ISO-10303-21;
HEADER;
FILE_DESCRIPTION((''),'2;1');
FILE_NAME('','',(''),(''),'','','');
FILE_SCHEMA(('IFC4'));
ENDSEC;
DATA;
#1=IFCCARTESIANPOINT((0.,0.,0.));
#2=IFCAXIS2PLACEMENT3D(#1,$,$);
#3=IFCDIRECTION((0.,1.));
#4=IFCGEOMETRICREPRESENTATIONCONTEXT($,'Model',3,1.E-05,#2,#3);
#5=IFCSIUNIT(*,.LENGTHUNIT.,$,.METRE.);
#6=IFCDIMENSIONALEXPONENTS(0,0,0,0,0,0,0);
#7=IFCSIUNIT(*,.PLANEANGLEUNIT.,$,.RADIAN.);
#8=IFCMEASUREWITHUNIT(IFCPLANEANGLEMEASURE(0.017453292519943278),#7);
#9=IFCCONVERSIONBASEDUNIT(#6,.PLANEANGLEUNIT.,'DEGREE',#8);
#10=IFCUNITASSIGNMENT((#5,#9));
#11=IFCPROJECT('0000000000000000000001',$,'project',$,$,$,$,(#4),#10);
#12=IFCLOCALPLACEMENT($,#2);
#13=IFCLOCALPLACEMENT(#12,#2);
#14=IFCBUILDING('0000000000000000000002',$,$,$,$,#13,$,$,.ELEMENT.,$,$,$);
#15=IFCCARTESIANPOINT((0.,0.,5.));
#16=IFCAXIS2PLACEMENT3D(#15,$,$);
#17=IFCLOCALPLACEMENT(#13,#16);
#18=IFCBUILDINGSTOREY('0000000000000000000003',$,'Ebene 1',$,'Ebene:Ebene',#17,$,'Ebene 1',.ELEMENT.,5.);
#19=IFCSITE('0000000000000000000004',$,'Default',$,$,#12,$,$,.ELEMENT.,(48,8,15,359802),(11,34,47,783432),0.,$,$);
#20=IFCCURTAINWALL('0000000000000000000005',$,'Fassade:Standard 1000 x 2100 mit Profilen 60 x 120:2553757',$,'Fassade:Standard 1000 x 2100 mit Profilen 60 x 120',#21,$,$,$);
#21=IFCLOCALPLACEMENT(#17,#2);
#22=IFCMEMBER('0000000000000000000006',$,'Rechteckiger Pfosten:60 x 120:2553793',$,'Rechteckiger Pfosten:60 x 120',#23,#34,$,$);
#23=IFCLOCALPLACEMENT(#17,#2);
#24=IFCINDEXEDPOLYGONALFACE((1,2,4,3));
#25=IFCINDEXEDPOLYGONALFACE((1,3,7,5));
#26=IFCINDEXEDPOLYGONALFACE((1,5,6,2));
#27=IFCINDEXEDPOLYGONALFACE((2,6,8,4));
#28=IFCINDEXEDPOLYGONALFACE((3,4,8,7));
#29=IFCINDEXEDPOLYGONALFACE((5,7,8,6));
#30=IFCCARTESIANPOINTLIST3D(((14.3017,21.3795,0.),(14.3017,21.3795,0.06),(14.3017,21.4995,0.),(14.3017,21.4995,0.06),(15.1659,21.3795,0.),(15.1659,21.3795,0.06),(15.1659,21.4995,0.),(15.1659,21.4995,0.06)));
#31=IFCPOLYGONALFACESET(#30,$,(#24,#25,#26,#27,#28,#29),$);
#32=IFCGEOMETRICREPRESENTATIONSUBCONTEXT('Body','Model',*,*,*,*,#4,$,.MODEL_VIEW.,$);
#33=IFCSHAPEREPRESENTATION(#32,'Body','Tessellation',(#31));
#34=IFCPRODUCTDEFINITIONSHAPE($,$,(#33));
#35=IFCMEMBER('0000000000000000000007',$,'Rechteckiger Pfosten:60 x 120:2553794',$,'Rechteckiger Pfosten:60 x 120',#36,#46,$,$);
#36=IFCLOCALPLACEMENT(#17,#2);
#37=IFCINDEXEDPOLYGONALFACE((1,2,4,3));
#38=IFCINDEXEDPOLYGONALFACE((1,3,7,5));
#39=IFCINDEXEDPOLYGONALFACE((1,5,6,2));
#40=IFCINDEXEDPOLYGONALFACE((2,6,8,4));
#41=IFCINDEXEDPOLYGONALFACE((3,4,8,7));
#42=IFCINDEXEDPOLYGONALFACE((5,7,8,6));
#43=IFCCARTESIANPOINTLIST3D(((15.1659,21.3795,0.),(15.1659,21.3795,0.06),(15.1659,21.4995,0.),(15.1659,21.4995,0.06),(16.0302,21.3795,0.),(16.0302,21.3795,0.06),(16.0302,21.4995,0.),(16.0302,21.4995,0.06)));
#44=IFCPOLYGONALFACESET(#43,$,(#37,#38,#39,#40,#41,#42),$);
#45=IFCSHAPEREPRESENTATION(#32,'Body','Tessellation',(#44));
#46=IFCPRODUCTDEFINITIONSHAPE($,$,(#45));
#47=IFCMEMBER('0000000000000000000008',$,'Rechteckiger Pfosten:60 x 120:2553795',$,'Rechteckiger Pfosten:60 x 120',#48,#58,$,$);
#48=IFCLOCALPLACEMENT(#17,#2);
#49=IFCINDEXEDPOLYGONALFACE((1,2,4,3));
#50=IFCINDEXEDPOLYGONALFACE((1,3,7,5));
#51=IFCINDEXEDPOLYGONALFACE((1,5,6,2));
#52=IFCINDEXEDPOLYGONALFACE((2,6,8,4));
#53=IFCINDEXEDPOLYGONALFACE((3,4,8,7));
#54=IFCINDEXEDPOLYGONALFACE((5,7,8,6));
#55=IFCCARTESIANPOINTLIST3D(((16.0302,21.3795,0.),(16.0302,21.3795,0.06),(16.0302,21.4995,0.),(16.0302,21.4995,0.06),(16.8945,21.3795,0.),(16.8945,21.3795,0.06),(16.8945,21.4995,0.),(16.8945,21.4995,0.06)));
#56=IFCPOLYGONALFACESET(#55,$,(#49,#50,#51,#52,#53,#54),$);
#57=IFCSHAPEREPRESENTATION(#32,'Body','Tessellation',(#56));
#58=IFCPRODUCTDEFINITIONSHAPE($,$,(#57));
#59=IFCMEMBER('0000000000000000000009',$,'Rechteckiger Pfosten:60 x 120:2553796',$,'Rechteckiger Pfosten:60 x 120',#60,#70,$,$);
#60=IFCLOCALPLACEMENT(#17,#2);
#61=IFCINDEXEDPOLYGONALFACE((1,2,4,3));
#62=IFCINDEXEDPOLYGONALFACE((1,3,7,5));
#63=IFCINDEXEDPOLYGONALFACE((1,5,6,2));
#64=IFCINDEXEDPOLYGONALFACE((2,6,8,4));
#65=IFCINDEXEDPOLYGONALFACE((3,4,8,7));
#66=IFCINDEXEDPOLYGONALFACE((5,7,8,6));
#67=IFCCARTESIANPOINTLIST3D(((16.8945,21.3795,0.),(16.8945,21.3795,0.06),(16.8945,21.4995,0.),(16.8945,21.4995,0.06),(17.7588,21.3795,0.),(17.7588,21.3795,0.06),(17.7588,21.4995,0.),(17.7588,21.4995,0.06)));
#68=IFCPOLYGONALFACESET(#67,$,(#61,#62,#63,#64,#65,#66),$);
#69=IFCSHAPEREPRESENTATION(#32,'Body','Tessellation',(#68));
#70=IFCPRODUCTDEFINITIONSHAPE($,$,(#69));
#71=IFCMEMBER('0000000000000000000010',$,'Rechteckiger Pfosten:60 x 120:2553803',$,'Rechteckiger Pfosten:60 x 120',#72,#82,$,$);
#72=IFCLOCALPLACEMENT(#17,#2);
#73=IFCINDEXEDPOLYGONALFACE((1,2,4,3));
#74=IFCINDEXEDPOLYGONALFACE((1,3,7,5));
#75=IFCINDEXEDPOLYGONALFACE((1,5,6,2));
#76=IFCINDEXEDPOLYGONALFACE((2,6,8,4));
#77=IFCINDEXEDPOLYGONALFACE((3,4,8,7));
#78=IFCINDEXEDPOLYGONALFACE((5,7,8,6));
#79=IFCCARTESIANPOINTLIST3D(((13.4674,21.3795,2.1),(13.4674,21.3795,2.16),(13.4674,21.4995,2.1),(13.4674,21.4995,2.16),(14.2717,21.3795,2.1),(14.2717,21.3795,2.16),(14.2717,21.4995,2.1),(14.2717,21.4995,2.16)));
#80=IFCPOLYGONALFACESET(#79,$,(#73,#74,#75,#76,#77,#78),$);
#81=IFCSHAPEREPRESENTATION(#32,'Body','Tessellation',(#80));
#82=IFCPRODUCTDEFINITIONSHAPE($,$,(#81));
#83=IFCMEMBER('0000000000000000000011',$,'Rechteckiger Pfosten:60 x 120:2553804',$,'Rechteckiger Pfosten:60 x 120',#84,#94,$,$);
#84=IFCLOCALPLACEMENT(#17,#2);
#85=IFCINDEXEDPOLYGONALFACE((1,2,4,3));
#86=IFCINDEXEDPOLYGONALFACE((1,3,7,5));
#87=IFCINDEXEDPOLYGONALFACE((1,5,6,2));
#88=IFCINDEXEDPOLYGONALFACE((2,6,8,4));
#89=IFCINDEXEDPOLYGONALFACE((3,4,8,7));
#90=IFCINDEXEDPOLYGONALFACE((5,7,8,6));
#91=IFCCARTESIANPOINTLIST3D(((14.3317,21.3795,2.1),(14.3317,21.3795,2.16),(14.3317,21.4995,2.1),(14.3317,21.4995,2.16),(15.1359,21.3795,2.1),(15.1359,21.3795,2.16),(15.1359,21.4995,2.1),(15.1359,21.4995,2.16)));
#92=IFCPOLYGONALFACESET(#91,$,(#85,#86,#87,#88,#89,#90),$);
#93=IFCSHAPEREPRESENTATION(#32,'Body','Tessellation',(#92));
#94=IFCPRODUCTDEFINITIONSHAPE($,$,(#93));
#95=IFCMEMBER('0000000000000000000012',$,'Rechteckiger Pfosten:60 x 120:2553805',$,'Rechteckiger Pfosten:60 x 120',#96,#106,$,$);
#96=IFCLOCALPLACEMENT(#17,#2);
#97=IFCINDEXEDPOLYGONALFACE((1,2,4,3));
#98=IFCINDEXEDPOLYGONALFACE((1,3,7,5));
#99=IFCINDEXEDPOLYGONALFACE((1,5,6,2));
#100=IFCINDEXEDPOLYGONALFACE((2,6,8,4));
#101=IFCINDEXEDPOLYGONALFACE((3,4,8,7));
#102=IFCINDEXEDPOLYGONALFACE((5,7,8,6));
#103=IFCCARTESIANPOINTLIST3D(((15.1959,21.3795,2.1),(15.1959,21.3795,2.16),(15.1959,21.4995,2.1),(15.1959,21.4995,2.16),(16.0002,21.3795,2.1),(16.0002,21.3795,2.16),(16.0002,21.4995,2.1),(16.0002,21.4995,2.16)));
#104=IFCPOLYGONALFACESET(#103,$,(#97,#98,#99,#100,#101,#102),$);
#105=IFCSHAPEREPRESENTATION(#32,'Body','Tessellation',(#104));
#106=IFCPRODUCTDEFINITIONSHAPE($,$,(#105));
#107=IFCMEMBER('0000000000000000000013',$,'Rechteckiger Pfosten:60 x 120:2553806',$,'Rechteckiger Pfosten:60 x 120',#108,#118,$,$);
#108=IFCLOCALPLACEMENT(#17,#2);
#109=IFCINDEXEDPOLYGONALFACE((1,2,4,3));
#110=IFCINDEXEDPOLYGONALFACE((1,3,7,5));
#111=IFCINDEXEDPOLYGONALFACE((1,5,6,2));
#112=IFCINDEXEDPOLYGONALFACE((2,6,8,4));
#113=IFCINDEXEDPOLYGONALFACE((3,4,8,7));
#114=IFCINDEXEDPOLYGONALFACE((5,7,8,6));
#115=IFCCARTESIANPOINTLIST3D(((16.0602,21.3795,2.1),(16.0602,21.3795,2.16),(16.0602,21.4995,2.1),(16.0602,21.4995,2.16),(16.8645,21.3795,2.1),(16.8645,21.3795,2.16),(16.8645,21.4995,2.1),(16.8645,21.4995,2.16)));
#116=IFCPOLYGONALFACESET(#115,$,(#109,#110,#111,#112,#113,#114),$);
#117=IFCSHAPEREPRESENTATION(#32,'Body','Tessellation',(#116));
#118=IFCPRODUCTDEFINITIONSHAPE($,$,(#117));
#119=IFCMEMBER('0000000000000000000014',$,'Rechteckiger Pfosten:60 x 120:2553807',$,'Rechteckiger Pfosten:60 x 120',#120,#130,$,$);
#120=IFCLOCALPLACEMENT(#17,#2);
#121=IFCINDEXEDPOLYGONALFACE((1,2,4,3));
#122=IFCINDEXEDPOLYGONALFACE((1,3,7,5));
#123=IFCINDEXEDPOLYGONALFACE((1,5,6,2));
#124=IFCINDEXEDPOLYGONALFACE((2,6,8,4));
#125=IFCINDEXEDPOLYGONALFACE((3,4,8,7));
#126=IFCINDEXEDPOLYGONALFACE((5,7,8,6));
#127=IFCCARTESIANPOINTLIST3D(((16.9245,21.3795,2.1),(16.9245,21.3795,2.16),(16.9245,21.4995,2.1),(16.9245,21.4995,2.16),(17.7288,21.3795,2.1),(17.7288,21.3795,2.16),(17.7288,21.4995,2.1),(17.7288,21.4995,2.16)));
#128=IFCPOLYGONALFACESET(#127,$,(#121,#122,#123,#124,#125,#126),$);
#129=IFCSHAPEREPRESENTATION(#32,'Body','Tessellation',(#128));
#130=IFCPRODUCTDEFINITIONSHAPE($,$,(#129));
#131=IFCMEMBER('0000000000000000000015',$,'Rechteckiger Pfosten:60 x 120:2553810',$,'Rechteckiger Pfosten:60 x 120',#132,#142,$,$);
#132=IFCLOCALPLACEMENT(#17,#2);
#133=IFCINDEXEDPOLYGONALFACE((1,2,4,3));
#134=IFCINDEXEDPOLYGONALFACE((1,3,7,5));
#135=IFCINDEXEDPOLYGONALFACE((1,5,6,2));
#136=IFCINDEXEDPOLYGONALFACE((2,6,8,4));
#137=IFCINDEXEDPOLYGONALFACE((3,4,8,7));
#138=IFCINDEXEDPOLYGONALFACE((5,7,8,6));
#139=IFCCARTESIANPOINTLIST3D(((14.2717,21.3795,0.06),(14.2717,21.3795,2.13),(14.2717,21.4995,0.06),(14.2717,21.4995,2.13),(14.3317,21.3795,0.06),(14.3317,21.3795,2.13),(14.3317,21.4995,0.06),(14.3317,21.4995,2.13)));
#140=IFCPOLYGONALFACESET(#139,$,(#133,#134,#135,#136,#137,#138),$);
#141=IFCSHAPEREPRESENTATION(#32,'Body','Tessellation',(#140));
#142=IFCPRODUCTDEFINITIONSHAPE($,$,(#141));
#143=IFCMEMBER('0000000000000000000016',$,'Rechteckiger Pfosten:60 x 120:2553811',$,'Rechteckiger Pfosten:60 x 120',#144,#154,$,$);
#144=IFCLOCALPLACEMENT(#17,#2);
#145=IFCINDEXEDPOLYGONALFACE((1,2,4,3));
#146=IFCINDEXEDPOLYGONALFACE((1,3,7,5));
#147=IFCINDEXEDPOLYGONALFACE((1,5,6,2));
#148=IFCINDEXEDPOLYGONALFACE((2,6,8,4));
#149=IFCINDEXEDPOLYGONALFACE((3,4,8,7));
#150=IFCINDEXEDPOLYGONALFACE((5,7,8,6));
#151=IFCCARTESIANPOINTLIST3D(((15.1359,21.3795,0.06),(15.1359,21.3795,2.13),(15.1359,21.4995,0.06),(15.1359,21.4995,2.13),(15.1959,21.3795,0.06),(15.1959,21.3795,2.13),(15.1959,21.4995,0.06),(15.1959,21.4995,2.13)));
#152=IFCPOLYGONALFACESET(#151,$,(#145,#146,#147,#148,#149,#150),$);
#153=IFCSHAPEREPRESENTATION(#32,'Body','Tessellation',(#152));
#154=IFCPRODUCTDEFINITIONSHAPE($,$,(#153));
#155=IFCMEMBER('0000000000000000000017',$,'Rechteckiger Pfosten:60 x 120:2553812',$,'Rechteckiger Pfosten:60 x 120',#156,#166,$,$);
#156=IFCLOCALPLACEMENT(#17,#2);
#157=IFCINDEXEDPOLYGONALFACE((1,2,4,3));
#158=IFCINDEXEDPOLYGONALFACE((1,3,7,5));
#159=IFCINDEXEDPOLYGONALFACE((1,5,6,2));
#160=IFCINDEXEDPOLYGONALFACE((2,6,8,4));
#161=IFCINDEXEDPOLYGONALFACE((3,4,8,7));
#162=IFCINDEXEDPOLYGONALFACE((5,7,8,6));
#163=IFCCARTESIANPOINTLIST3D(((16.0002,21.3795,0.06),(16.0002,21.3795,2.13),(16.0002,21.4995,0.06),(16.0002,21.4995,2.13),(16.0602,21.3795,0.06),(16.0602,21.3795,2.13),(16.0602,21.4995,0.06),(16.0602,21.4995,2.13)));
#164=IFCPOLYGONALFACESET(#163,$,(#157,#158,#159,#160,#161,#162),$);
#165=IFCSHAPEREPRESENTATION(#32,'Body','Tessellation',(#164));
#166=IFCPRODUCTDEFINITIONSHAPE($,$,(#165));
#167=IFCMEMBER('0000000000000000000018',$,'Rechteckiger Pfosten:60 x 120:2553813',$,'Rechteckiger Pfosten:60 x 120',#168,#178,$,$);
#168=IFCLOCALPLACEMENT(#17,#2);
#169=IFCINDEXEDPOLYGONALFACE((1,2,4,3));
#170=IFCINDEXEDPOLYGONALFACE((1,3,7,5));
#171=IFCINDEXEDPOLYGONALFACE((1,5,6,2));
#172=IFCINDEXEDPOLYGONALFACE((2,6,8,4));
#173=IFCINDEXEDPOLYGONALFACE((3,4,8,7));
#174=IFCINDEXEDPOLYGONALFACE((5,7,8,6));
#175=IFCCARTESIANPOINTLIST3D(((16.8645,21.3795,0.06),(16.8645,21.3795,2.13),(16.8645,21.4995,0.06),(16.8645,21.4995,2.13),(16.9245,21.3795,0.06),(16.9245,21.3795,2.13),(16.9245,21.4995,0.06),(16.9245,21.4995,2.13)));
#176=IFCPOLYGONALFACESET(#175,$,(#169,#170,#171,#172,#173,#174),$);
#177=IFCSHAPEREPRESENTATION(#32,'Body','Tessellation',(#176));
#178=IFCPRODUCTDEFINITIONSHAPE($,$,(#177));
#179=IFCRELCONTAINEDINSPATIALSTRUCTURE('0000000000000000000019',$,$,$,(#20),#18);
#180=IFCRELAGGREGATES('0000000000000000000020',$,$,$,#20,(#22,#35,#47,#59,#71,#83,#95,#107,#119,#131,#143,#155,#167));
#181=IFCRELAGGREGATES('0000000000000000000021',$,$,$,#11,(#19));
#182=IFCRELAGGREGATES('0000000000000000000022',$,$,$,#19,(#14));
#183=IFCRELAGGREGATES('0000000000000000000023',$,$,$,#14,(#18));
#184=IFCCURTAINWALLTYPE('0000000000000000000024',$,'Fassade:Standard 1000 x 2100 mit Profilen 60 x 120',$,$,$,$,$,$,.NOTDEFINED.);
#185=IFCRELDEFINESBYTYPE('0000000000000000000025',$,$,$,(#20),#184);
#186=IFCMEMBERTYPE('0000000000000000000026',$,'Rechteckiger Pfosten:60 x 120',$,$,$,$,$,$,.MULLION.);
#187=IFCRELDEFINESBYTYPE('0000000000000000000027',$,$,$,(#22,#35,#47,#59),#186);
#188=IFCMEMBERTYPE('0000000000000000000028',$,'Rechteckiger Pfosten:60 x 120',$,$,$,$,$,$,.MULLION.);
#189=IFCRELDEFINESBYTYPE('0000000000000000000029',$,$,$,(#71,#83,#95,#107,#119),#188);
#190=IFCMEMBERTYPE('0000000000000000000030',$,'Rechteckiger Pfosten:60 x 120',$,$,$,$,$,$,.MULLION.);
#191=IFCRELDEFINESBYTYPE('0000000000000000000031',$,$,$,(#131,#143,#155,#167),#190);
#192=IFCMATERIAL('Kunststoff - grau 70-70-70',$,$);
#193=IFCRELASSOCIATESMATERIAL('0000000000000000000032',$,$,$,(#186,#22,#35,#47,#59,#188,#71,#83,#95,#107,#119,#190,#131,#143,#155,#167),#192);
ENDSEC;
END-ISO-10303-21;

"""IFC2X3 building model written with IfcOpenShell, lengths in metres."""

from ifc_helpers import new_model, entity, si_unit, converted_unit, direction, frame, frame_2d, origin, origin_2d_with_axis, place, context, subcontext, project, spatial, rectangle, extrude, source, transform, mapped, material, type_object, type_shapes, element, aggregate, save


model = new_model("IFC2X3")

# Units and contexts
model_context = context("Model", 3, precision=1e-05, world=origin(), true_north=direction((0.0, 1.0)))
body_context = subcontext(model_context, "Body", "Model", "MODEL_VIEW")
ifc_project = project(units=[si_unit("LENGTHUNIT", "METRE"), converted_unit("PLANEANGLEUNIT", "DEGREE", entity("IfcPlaneAngleMeasure", 0.017453292519943278), si_unit("PLANEANGLEUNIT", "RADIAN"), dimensions=[0, 0, 0, 0, 0, 0, 0])], contexts=[model_context])

# Site, building, storey
site_placement = place(None, origin())
site = spatial("IfcSite", under=ifc_project, at=site_placement, Name="Default", CompositionType="ELEMENT", RefLatitude=(48, 8, 15, 359802), RefLongitude=(11, 34, 47, 783432), RefElevation=0.0)
building_placement = place(site_placement, origin())
building = spatial("IfcBuilding", under=site, at=building_placement, CompositionType="ELEMENT")
storey_placement = place(building_placement, frame((0.0, 0.0, 5.0)))
storey = spatial("IfcBuildingStorey", under=building, at=storey_placement, Name="Ebene 1", ObjectType="Ebene:Ebene", LongName="Ebene 1", CompositionType="ELEMENT", Elevation=5.0)

# Curtain wall, members
curtain_wall_type = type_object("IfcCurtainWallType", Name="Fassade:Standard 1000 x 2100 mit Profilen 60 x 120", PredefinedType="NOTDEFINED")
curtain_wall_placement = place(storey_placement, frame((0.0, 0.0, -5.0)))
curtain_wall = element("IfcCurtainWall", 1, at=curtain_wall_placement, inside=storey, type_object=curtain_wall_type, Name="Fassade:Standard 1000 x 2100 mit Profilen 60 x 120:2553757", ObjectType="Fassade:Standard 1000 x 2100 mit Profilen 60 x 120")
ifc_material_1 = material(Name="Kunststoff - grau 70-70-70")
member_type_1 = type_object("IfcMemberType", Name="Rechteckiger Pfosten:60 x 120", PredefinedType="MULLION", material=ifc_material_1)
shared_shape_1 = source(origin(), body_context, "Body", "SweptSolid", [
    extrude(rectangle(XDim=0.06, YDim=0.12, at=origin_2d_with_axis()), frame((-0.03, 0.0, -0.8643), z_axis=(0.0, 0.0, 1.0), x_axis=(-1.0, 0.0, 0.0)), (0.0, 0.0, 1.0), 0.8643),
])
type_shapes(member_type_1, [shared_shape_1])
member_1_placement = place(curtain_wall_placement, frame((14.3017, 21.4395, 5.0), z_axis=(-1.0, 0.0, 0.0), x_axis=(0.0, 0.0, -1.0)))
member_1 = element("IfcMember", 2, at=member_1_placement, type_object=member_type_1, material=ifc_material_1, Name="Rechteckiger Pfosten:60 x 120:2553793", ObjectType="Rechteckiger Pfosten:60 x 120", context=body_context, shape_type="MappedRepresentation", body=[
    mapped(shared_shape_1, transform((0.0, 0.0, 0.0), scale=1.0)),
])
member_2_placement = place(curtain_wall_placement, frame((15.1659, 21.4395, 5.0), z_axis=(-1.0, 0.0, 0.0), x_axis=(0.0, 0.0, -1.0)))
member_2 = element("IfcMember", 3, at=member_2_placement, type_object=member_type_1, material=ifc_material_1, Name="Rechteckiger Pfosten:60 x 120:2553794", ObjectType="Rechteckiger Pfosten:60 x 120", context=body_context, shape_type="MappedRepresentation", body=[
    mapped(shared_shape_1, transform((0.0, 0.0, 0.0), scale=1.0)),
])
member_3_placement = place(curtain_wall_placement, frame((16.0302, 21.4395, 5.0), z_axis=(-1.0, 0.0, 0.0), x_axis=(0.0, 0.0, -1.0)))
member_3 = element("IfcMember", 4, at=member_3_placement, type_object=member_type_1, material=ifc_material_1, Name="Rechteckiger Pfosten:60 x 120:2553795", ObjectType="Rechteckiger Pfosten:60 x 120", context=body_context, shape_type="MappedRepresentation", body=[
    mapped(shared_shape_1, transform((0.0, 0.0, 0.0), scale=1.0)),
])
member_4_placement = place(curtain_wall_placement, frame((16.8945, 21.4395, 5.0), z_axis=(-1.0, 0.0, 0.0), x_axis=(0.0, 0.0, -1.0)))
member_4 = element("IfcMember", 5, at=member_4_placement, type_object=member_type_1, material=ifc_material_1, Name="Rechteckiger Pfosten:60 x 120:2553796", ObjectType="Rechteckiger Pfosten:60 x 120", context=body_context, shape_type="MappedRepresentation", body=[
    mapped(shared_shape_1, transform((0.0, 0.0, 0.0), scale=1.0)),
])
member_type_2 = type_object("IfcMemberType", Name="Rechteckiger Pfosten:60 x 120", PredefinedType="MULLION", material=ifc_material_1)
shared_shape_2 = source(origin(), body_context, "Body", "SweptSolid", [
    extrude(rectangle(XDim=0.06, YDim=0.12, at=frame_2d((0.0, 0.0), x_axis=(1.0, 0.0))), frame((0.0, 0.0, -0.8043), z_axis=(0.0, 0.0, 1.0), x_axis=(-1.0, 0.0, 0.0)), (0.0, 0.0, 1.0), 0.8043),
])
type_shapes(member_type_2, [shared_shape_2])
member_5_placement = place(curtain_wall_placement, frame((14.2717, 21.4395, 7.13), z_axis=(1.0, 0.0, 0.0), x_axis=(0.0, 0.0, 1.0)))
member_5 = element("IfcMember", 6, at=member_5_placement, type_object=member_type_2, material=ifc_material_1, Name="Rechteckiger Pfosten:60 x 120:2553803", ObjectType="Rechteckiger Pfosten:60 x 120", context=body_context, shape_type="MappedRepresentation", body=[
    mapped(shared_shape_2, transform((0.0, 0.0, 0.0), scale=1.0)),
])
member_6_placement = place(curtain_wall_placement, frame((15.1359, 21.4395, 7.13), z_axis=(1.0, 0.0, 0.0), x_axis=(0.0, 0.0, 1.0)))
member_6 = element("IfcMember", 7, at=member_6_placement, type_object=member_type_2, material=ifc_material_1, Name="Rechteckiger Pfosten:60 x 120:2553804", ObjectType="Rechteckiger Pfosten:60 x 120", context=body_context, shape_type="MappedRepresentation", body=[
    mapped(shared_shape_2, transform((0.0, 0.0, 0.0), scale=1.0)),
])
member_7_placement = place(curtain_wall_placement, frame((16.0002, 21.4395, 7.13), z_axis=(1.0, 0.0, 0.0), x_axis=(0.0, 0.0, 1.0)))
member_7 = element("IfcMember", 8, at=member_7_placement, type_object=member_type_2, material=ifc_material_1, Name="Rechteckiger Pfosten:60 x 120:2553805", ObjectType="Rechteckiger Pfosten:60 x 120", context=body_context, shape_type="MappedRepresentation", body=[
    mapped(shared_shape_2, transform((0.0, 0.0, 0.0), scale=1.0)),
])
member_8_placement = place(curtain_wall_placement, frame((16.8645, 21.4395, 7.13), z_axis=(1.0, 0.0, 0.0), x_axis=(0.0, 0.0, 1.0)))
member_8 = element("IfcMember", 9, at=member_8_placement, type_object=member_type_2, material=ifc_material_1, Name="Rechteckiger Pfosten:60 x 120:2553806", ObjectType="Rechteckiger Pfosten:60 x 120", context=body_context, shape_type="MappedRepresentation", body=[
    mapped(shared_shape_2, transform((0.0, 0.0, 0.0), scale=1.0)),
])
member_9_placement = place(curtain_wall_placement, frame((17.7288, 21.4395, 7.13), z_axis=(1.0, 0.0, 0.0), x_axis=(0.0, 0.0, 1.0)))
member_9 = element("IfcMember", 10, at=member_9_placement, type_object=member_type_2, material=ifc_material_1, Name="Rechteckiger Pfosten:60 x 120:2553807", ObjectType="Rechteckiger Pfosten:60 x 120", context=body_context, shape_type="MappedRepresentation", body=[
    mapped(shared_shape_2, transform((0.0, 0.0, 0.0), scale=1.0)),
])
member_type_3 = type_object("IfcMemberType", Name="Rechteckiger Pfosten:60 x 120", PredefinedType="MULLION", material=ifc_material_1)
shared_shape_3 = source(origin(), body_context, "Body", "SweptSolid", [
    extrude(rectangle(XDim=0.06, YDim=0.12, at=origin_2d_with_axis()), frame((0.0, 0.0, -2.07), z_axis=(0.0, 0.0, 1.0), x_axis=(-1.0, 0.0, 0.0)), (0.0, 0.0, 1.0), 2.07),
])
type_shapes(member_type_3, [shared_shape_3])
member_10_placement = place(curtain_wall_placement, frame((14.3017, 21.4395, 5.06), z_axis=(0.0, 0.0, -1.0), x_axis=(1.0, 0.0, 0.0)))
member_10 = element("IfcMember", 11, at=member_10_placement, type_object=member_type_3, material=ifc_material_1, Name="Rechteckiger Pfosten:60 x 120:2553810", ObjectType="Rechteckiger Pfosten:60 x 120", context=body_context, shape_type="MappedRepresentation", body=[
    mapped(shared_shape_3, transform((0.0, 0.0, 0.0), scale=1.0)),
])
member_11_placement = place(curtain_wall_placement, frame((15.1659, 21.4395, 5.06), z_axis=(0.0, 0.0, -1.0), x_axis=(1.0, 0.0, 0.0)))
member_11 = element("IfcMember", 12, at=member_11_placement, type_object=member_type_3, material=ifc_material_1, Name="Rechteckiger Pfosten:60 x 120:2553811", ObjectType="Rechteckiger Pfosten:60 x 120", context=body_context, shape_type="MappedRepresentation", body=[
    mapped(shared_shape_3, transform((0.0, 0.0, 0.0), scale=1.0)),
])
member_12_placement = place(curtain_wall_placement, frame((16.0302, 21.4395, 5.06), z_axis=(0.0, 0.0, -1.0), x_axis=(1.0, 0.0, 0.0)))
member_12 = element("IfcMember", 13, at=member_12_placement, type_object=member_type_3, material=ifc_material_1, Name="Rechteckiger Pfosten:60 x 120:2553812", ObjectType="Rechteckiger Pfosten:60 x 120", context=body_context, shape_type="MappedRepresentation", body=[
    mapped(shared_shape_3, transform((0.0, 0.0, 0.0), scale=1.0)),
])
member_13_placement = place(curtain_wall_placement, frame((16.8945, 21.4395, 5.06), z_axis=(0.0, 0.0, -1.0), x_axis=(1.0, 0.0, 0.0)))
member_13 = element("IfcMember", 14, at=member_13_placement, type_object=member_type_3, material=ifc_material_1, Name="Rechteckiger Pfosten:60 x 120:2553813", ObjectType="Rechteckiger Pfosten:60 x 120", context=body_context, shape_type="MappedRepresentation", body=[
    mapped(shared_shape_3, transform((0.0, 0.0, 0.0), scale=1.0)),
])
aggregate(curtain_wall, [member_1, member_2, member_3, member_4, member_5, member_6, member_7, member_8, member_9, member_10, member_11, member_12, member_13])

save(model, "model.ifc")
